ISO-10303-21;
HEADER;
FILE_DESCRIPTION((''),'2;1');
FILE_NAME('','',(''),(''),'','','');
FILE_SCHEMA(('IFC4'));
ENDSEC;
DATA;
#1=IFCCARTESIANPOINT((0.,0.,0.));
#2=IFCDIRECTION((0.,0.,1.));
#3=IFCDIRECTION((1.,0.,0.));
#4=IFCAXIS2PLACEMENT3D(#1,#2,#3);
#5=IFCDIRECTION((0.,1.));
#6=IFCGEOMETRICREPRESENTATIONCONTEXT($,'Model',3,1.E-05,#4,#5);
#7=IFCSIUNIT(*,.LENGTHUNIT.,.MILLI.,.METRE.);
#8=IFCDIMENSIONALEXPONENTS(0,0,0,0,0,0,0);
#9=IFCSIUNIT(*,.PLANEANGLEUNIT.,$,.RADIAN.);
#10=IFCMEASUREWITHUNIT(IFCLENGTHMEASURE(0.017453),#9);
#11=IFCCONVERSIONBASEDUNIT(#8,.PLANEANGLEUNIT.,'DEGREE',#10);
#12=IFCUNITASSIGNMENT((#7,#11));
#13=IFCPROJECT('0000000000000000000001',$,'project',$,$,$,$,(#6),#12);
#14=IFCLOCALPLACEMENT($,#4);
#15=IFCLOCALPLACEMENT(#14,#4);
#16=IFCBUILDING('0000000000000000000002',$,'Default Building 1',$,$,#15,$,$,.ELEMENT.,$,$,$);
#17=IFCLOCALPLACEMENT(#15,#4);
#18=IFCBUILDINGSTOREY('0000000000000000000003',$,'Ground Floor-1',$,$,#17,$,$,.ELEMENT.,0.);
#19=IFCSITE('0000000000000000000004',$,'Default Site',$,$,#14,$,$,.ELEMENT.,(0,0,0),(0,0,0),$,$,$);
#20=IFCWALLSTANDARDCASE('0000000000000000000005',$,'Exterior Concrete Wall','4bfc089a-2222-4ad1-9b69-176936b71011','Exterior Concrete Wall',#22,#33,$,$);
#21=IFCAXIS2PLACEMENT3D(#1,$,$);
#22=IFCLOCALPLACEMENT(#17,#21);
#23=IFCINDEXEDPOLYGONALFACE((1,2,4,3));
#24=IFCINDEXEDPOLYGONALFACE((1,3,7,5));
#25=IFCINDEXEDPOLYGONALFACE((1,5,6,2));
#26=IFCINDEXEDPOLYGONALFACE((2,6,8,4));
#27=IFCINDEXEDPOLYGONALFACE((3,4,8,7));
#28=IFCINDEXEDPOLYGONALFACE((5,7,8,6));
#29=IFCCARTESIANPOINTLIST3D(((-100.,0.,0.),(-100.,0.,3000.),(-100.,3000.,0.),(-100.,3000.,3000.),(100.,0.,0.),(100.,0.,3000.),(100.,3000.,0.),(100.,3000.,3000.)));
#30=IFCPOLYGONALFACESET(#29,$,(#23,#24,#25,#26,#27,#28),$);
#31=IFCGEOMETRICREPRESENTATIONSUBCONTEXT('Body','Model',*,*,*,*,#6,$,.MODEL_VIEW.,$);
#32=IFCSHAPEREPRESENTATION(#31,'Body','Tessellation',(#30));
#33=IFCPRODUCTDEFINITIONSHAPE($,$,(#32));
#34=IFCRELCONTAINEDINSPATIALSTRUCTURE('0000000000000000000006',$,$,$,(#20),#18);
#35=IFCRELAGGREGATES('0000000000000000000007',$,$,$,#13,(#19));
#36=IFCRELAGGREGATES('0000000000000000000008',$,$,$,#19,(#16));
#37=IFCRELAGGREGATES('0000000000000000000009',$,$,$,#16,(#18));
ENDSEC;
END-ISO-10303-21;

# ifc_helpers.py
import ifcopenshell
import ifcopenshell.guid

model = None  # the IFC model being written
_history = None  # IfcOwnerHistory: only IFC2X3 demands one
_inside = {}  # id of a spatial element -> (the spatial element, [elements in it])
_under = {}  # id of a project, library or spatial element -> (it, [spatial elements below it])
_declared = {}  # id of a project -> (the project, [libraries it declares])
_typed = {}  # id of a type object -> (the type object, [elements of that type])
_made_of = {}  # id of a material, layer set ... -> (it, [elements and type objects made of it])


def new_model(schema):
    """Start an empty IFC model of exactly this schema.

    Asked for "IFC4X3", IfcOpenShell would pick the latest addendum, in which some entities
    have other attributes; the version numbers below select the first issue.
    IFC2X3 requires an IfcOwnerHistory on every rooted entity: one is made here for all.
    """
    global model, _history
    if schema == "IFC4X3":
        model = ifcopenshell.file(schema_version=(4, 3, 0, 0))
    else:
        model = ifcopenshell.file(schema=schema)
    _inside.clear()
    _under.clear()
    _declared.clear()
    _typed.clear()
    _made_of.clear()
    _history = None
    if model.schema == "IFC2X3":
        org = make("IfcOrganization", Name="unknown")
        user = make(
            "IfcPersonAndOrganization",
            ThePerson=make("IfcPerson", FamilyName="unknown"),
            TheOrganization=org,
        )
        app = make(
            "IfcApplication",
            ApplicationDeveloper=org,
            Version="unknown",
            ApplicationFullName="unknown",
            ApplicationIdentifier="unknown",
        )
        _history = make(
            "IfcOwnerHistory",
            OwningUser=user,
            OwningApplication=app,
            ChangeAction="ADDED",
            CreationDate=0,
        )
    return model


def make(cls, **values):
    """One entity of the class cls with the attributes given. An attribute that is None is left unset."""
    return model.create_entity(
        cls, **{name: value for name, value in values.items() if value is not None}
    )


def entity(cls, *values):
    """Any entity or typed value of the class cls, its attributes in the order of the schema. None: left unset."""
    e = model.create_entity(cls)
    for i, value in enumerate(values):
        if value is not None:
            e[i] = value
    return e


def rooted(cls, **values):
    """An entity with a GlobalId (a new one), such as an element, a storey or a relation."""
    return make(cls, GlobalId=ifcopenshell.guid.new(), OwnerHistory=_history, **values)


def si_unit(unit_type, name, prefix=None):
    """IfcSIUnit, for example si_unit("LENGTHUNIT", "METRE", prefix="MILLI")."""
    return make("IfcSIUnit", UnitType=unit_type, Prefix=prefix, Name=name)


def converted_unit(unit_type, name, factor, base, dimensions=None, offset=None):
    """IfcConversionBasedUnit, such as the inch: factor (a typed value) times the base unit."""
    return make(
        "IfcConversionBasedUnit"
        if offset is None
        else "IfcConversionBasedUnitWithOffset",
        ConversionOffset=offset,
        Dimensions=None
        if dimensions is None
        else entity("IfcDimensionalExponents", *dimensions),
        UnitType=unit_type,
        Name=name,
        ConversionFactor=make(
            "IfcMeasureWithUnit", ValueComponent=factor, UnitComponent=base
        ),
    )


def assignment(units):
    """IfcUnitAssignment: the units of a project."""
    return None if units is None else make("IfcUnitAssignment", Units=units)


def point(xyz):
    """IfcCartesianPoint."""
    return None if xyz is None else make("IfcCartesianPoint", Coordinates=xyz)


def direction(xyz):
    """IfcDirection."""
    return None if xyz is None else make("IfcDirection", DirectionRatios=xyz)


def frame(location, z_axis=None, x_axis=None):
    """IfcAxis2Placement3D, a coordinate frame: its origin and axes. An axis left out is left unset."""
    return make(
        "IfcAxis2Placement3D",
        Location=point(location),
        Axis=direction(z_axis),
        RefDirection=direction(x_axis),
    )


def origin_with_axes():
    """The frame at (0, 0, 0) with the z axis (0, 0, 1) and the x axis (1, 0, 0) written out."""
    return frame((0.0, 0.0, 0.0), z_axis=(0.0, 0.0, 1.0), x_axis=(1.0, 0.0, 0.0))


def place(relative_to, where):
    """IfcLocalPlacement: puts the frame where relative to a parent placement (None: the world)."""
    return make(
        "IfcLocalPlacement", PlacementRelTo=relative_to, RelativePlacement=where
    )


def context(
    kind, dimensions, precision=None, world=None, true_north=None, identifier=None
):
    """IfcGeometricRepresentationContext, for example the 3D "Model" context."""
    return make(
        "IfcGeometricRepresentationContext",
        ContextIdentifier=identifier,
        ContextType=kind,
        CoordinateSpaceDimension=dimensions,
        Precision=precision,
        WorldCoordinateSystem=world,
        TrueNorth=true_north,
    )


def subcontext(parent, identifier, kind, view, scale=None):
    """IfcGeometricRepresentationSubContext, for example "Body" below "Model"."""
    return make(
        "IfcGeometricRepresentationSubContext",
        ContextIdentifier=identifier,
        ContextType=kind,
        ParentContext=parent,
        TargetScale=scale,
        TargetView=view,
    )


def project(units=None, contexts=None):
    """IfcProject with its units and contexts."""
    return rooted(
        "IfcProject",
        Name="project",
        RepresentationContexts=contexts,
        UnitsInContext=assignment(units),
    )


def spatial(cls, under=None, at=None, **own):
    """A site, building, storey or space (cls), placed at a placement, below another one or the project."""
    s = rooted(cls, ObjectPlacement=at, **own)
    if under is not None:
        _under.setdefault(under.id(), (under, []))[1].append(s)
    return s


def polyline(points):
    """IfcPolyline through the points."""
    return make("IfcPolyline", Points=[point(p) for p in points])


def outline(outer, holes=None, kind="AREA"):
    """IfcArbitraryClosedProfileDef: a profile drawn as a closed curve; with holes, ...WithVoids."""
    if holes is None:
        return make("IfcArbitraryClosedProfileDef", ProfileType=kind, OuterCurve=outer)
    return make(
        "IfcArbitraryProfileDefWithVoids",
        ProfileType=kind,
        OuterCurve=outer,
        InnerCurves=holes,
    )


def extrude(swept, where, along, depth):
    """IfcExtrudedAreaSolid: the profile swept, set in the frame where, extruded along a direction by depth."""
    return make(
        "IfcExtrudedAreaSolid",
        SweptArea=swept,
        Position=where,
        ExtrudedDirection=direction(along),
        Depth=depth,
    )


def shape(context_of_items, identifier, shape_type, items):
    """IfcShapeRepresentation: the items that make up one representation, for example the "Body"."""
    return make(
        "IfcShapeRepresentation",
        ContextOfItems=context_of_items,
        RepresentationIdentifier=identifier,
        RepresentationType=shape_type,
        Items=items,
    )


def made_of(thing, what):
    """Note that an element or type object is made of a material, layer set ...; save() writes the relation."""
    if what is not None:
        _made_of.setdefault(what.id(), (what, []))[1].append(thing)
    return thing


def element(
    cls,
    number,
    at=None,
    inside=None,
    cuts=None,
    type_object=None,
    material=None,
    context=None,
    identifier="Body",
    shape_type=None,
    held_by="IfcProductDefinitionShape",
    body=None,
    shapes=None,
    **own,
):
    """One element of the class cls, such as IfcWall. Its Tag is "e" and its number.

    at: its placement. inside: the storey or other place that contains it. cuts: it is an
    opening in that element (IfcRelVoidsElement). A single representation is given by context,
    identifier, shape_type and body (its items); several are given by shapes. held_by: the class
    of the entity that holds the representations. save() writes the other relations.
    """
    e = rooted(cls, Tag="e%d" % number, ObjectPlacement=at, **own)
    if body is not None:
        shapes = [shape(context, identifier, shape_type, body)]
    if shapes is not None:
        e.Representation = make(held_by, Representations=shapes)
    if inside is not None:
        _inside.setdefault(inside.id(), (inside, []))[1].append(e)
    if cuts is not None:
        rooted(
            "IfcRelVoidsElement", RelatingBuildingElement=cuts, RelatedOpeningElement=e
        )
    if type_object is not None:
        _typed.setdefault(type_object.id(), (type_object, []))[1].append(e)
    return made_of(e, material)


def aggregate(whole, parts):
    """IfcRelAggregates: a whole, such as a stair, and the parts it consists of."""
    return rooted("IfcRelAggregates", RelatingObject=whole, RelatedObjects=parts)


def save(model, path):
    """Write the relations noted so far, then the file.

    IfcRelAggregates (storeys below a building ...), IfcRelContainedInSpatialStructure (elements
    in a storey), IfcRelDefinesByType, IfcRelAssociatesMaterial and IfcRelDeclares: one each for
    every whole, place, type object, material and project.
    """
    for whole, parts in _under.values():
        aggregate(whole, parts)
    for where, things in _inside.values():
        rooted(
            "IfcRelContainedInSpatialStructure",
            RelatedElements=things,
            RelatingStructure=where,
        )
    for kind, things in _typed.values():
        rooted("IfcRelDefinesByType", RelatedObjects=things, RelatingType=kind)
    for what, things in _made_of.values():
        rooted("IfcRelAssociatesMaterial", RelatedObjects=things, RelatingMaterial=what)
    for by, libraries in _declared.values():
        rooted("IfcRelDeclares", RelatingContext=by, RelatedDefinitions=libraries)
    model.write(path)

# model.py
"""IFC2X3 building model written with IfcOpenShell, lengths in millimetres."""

from ifc_helpers import new_model, entity, si_unit, converted_unit, direction, frame, origin_with_axes, place, context, subcontext, project, spatial, polyline, outline, extrude, element, save


model = new_model("IFC2X3")

# Units and contexts
model_context = context("Model", 3, precision=1e-05, world=origin_with_axes(), true_north=direction((0.0, 1.0)))
body_context = subcontext(model_context, "Body", "Model", "MODEL_VIEW")
ifc_project = project(units=[si_unit("LENGTHUNIT", "METRE", prefix="MILLI"), converted_unit("PLANEANGLEUNIT", "DEGREE", entity("IfcLengthMeasure", 0.017453), si_unit("PLANEANGLEUNIT", "RADIAN"), dimensions=[0, 0, 0, 0, 0, 0, 0])], contexts=[model_context])

# Site, building, storey
site_placement = place(None, origin_with_axes())
site = spatial("IfcSite", under=ifc_project, at=site_placement, Name="Default Site", CompositionType="ELEMENT", RefLatitude=(0, 0, 0), RefLongitude=(0, 0, 0))
building_placement = place(site_placement, origin_with_axes())
building = spatial("IfcBuilding", under=site, at=building_placement, Name="Default Building 1", CompositionType="ELEMENT")
storey_placement = place(building_placement, origin_with_axes())
storey = spatial("IfcBuildingStorey", under=building, at=storey_placement, Name="Ground Floor-1", CompositionType="ELEMENT", Elevation=0.0)

# Wall
wall_placement = place(storey_placement, frame((0.0, 3000.0, 0.0), z_axis=(0.0, 0.0, 1.0), x_axis=(0.0, -1.0, 0.0)))
element("IfcWallStandardCase", 1, at=wall_placement, inside=storey, Name="Exterior Concrete Wall", Description="4bfc089a-2222-4ad1-9b69-176936b71011", ObjectType="Exterior Concrete Wall", context=body_context, shape_type="SweptSolid", body=[
    extrude(outline(polyline([(0.0, -100.0), (0.0, 100.0), (3000.0, 100.0), (3000.0, -100.0), (0.0, -100.0)])), origin_with_axes(), (0.0, 0.0, 1.0), 3000.0),
])

save(model, "model.ifc")
